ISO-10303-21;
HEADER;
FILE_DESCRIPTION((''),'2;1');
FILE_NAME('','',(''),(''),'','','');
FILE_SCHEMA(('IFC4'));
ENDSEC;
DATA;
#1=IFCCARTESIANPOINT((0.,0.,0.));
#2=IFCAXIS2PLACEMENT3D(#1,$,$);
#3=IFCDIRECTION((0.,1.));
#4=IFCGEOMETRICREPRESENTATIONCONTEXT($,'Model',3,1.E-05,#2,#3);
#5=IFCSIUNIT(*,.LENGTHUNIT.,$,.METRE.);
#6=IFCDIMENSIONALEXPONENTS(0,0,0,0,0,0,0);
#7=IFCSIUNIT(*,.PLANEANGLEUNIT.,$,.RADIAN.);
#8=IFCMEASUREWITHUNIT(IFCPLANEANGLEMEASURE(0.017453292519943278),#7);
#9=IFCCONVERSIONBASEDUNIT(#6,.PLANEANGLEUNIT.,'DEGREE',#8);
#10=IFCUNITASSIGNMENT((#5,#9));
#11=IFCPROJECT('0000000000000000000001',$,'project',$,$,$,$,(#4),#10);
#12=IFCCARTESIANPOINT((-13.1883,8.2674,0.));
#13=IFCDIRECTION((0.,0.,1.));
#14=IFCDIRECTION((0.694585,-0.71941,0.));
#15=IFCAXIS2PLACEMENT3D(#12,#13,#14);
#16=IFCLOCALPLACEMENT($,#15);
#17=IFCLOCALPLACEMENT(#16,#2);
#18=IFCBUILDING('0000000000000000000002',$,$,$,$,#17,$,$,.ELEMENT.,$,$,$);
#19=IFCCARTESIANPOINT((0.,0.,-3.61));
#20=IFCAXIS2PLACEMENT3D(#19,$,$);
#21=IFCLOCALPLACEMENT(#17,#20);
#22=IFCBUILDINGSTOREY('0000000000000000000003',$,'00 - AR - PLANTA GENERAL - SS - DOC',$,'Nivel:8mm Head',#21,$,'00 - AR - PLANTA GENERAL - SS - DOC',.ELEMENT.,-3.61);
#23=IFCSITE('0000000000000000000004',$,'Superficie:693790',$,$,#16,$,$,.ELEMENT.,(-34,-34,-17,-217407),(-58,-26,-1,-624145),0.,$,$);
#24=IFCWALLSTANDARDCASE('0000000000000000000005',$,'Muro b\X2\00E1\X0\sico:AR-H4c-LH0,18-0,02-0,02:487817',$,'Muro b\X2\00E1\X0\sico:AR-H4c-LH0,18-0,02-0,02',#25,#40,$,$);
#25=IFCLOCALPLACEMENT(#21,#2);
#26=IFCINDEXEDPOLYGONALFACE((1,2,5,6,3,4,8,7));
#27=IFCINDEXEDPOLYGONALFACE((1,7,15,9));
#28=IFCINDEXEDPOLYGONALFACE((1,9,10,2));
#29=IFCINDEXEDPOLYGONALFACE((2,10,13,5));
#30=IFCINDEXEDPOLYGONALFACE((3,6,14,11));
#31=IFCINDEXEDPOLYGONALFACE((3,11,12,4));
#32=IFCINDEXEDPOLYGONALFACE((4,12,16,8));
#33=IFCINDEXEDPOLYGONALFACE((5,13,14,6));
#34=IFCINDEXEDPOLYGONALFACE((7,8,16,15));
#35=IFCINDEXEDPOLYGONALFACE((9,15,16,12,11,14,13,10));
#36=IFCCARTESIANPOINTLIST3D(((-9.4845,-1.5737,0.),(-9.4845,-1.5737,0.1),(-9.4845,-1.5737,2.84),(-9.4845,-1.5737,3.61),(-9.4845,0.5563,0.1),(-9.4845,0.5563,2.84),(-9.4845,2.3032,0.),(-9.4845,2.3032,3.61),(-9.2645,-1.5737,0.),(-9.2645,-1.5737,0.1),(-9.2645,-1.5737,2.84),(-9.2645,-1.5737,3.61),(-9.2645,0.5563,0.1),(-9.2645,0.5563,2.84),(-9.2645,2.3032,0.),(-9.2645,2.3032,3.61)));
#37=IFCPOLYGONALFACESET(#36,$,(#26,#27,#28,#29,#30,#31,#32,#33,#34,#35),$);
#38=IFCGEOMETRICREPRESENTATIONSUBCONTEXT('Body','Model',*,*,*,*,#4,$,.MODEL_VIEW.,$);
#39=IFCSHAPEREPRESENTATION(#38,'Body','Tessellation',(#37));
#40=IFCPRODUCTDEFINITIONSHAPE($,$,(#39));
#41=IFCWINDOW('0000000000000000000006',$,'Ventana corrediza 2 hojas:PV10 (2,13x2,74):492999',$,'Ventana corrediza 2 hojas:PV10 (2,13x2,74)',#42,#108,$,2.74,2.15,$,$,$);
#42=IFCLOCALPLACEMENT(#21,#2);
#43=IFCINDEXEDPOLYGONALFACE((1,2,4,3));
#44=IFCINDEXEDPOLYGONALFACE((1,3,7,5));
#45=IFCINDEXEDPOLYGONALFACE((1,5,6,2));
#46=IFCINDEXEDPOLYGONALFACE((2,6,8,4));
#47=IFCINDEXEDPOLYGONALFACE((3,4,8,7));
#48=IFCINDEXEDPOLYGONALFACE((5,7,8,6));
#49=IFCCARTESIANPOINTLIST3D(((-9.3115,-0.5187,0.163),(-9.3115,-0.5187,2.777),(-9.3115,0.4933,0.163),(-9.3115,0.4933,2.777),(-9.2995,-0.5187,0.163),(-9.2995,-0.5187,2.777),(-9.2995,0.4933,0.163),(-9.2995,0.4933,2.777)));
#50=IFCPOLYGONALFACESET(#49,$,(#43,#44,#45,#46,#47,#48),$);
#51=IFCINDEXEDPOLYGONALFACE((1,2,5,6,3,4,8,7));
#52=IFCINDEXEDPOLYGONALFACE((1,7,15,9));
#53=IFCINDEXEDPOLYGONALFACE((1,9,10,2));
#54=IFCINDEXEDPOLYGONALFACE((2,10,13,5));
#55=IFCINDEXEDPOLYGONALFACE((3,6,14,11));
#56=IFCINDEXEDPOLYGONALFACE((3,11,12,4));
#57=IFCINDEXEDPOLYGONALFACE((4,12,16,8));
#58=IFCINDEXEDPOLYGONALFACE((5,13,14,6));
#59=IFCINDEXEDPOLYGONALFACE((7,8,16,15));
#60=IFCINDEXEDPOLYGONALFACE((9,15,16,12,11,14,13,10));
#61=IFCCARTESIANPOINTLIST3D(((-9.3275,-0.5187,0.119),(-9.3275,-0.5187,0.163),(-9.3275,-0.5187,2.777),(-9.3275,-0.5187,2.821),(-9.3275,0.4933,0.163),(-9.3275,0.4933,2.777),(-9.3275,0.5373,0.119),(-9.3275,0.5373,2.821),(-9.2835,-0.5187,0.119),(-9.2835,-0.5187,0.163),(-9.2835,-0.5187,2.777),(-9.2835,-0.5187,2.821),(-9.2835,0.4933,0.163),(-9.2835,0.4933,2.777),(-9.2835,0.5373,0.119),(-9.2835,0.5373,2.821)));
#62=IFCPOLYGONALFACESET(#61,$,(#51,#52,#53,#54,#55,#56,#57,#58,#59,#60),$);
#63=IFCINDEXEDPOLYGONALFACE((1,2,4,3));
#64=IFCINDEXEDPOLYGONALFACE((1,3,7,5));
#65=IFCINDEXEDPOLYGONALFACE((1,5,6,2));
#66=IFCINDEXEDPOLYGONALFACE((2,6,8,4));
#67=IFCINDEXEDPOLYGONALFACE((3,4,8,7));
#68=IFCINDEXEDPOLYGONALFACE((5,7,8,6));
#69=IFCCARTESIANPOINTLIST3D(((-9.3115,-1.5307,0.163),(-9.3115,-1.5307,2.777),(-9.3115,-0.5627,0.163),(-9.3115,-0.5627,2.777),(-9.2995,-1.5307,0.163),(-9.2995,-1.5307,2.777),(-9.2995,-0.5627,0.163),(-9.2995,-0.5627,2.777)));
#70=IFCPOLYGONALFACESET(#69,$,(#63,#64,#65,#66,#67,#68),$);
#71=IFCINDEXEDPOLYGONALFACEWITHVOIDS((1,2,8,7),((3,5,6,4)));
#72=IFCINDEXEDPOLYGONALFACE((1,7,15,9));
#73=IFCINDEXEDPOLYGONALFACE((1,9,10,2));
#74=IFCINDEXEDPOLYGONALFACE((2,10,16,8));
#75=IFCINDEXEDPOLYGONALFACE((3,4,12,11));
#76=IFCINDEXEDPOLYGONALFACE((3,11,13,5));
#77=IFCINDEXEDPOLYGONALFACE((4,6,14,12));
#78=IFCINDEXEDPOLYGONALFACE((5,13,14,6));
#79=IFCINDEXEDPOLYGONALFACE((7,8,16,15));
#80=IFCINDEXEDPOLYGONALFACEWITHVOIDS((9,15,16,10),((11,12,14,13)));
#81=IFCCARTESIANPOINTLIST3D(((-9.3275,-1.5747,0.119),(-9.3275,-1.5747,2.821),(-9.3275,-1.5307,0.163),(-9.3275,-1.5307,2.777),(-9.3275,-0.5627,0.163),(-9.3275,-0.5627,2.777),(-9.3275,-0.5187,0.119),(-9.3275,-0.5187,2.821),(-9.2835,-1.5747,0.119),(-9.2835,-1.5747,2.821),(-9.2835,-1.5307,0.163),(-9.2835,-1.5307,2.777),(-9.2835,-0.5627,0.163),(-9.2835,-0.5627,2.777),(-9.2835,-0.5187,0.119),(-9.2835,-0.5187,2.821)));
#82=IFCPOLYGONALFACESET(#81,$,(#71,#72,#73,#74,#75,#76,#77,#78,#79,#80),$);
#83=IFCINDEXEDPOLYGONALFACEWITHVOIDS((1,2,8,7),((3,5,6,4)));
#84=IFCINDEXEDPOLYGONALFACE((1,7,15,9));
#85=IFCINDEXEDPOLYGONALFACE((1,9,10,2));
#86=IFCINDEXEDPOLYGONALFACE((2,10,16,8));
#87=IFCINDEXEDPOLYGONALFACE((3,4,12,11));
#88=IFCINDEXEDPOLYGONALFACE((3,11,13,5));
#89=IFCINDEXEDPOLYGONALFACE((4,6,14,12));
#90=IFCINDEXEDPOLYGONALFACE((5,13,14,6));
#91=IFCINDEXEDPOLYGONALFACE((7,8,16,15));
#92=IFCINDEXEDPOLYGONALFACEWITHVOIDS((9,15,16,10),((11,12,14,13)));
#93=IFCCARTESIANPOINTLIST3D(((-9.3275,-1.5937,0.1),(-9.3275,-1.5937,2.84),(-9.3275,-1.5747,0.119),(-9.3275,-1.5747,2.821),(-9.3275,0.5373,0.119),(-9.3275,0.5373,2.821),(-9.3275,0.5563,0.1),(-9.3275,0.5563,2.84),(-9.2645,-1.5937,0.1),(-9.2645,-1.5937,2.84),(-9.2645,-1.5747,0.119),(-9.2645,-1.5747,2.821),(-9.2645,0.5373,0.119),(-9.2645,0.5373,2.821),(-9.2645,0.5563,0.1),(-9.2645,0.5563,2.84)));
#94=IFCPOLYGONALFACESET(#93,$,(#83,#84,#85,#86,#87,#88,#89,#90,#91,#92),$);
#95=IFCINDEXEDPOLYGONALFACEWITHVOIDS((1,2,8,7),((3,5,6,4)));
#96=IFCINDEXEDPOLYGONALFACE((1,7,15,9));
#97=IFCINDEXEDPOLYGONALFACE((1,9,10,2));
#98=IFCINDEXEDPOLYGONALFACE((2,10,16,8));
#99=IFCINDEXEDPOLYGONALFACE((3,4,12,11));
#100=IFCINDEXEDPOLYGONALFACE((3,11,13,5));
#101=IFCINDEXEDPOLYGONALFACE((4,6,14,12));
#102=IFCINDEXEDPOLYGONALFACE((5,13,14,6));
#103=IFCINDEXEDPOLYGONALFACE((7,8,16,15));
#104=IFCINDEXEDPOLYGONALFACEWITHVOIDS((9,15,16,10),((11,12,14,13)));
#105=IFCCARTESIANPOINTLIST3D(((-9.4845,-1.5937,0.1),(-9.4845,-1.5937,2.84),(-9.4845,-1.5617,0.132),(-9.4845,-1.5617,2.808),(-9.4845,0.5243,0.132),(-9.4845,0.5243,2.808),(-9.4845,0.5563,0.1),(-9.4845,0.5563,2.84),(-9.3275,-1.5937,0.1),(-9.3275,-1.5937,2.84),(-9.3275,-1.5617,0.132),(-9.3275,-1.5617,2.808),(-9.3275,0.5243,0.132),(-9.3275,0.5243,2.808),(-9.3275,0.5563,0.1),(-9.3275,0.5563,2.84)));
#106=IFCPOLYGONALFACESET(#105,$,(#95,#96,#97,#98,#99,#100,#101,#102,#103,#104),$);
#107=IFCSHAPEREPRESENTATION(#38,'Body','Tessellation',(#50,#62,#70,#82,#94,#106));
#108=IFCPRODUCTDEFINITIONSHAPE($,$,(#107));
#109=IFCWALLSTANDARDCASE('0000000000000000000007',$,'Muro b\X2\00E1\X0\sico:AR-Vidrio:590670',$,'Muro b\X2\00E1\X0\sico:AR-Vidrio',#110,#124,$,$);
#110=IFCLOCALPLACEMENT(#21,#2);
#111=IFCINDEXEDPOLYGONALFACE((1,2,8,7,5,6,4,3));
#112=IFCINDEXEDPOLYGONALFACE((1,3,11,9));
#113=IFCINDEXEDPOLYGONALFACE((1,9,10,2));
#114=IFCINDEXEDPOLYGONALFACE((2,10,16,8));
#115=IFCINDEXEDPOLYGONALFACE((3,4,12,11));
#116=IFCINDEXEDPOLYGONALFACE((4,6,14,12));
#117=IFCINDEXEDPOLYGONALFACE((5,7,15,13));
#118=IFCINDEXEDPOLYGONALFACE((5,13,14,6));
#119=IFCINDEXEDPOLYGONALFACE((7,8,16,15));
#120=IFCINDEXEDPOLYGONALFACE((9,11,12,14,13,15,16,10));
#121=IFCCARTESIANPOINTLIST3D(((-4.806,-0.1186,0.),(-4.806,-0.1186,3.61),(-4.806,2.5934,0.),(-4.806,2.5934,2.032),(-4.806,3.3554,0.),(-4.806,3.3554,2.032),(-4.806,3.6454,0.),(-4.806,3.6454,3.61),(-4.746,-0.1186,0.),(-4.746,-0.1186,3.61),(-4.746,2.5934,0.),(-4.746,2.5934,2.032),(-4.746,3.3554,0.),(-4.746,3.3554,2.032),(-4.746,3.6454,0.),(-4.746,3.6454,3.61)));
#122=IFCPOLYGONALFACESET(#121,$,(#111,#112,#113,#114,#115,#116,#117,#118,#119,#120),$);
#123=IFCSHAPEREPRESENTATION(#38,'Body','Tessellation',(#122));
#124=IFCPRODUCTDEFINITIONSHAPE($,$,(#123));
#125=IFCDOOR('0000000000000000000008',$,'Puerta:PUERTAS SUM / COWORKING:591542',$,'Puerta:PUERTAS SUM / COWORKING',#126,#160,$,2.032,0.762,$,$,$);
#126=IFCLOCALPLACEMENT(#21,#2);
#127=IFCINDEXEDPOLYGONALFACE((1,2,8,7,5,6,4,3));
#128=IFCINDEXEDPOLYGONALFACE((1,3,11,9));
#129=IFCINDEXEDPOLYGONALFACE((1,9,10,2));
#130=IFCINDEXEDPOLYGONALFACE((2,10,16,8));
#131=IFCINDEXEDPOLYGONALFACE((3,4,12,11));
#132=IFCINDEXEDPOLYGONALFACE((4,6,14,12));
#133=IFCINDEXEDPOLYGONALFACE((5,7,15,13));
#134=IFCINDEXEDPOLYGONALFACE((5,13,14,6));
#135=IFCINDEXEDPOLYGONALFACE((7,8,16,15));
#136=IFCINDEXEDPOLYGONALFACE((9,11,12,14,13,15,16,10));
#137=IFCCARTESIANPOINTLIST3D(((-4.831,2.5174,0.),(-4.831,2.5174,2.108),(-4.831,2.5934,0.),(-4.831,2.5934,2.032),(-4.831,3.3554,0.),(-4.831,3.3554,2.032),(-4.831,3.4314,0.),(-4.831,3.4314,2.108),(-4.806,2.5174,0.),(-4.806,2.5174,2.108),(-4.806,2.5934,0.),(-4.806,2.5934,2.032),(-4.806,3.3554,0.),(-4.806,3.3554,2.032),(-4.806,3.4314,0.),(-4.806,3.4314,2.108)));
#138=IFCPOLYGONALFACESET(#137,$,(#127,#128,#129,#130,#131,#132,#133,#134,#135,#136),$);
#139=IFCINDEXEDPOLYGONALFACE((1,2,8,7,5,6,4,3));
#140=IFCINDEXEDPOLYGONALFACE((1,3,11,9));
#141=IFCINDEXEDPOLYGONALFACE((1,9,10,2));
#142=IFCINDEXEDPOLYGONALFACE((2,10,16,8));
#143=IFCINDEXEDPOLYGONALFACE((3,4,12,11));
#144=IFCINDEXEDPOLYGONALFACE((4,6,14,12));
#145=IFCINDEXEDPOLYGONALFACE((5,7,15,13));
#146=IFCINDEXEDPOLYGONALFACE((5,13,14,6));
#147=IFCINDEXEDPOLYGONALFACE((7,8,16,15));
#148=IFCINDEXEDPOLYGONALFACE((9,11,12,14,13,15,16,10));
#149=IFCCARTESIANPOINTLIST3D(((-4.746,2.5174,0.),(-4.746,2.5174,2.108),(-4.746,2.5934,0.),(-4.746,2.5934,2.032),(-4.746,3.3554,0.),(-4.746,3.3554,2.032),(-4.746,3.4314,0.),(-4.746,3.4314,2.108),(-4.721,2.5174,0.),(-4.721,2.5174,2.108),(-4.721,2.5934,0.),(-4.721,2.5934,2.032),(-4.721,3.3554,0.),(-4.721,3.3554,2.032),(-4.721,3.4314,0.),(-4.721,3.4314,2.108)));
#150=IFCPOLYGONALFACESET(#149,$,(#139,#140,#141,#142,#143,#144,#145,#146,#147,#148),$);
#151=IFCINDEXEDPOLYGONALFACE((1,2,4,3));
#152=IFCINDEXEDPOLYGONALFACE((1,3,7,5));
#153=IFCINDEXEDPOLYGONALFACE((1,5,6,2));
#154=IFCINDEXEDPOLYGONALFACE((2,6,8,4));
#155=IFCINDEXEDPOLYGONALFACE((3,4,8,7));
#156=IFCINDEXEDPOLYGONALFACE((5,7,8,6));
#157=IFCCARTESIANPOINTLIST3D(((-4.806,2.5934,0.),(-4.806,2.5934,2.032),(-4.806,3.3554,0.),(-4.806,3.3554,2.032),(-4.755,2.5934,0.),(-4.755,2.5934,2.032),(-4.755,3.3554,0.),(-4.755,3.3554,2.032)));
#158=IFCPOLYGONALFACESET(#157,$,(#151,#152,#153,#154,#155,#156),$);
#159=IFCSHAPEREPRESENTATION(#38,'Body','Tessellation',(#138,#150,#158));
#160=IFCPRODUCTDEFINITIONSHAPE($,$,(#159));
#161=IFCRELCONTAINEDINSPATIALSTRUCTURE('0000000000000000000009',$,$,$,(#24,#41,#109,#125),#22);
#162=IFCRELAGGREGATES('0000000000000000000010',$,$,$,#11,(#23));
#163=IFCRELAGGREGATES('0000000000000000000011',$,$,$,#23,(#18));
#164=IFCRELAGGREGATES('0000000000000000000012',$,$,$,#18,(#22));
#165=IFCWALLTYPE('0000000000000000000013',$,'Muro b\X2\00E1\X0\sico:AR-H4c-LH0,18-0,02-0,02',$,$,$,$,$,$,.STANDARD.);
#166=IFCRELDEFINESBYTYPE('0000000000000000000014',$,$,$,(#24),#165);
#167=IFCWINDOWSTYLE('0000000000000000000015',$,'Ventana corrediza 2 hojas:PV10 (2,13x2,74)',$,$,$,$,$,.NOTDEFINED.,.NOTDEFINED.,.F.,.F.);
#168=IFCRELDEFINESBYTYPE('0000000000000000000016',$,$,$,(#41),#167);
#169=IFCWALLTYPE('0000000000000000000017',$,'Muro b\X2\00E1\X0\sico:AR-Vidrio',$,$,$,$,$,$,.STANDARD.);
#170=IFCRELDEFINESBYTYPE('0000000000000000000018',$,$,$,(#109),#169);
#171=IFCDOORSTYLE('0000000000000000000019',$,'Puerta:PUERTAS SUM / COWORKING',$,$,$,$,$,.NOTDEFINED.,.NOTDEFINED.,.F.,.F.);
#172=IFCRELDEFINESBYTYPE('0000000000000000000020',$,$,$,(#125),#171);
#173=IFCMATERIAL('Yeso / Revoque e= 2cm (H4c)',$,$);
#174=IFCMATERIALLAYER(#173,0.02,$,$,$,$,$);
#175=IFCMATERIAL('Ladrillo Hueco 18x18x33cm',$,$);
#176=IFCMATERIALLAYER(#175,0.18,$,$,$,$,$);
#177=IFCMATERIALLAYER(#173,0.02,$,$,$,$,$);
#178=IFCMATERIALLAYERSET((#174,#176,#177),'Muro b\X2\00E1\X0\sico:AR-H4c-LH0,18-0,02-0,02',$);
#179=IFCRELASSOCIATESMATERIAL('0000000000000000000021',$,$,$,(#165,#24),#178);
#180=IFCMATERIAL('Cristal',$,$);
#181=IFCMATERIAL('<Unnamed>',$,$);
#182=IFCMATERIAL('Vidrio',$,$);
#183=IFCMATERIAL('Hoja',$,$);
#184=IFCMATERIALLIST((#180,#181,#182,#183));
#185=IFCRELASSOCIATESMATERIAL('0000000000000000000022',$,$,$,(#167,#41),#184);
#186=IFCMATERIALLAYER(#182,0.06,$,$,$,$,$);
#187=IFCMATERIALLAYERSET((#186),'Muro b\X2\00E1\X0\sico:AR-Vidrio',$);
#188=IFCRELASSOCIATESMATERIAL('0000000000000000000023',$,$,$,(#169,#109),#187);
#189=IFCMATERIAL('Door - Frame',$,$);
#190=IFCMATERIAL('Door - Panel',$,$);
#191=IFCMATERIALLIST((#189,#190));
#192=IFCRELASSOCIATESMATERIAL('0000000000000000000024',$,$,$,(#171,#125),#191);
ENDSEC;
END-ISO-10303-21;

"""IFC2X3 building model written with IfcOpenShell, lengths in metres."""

from ifc_helpers import new_model, entity, si_unit, converted_unit, direction, frame, frame_2d, origin, origin_2d_with_axis, place, context, subcontext, project, spatial, polyline, rectangle, outline, extrude, source, transform, mapped, material, material_list, layer, layer_set, layer_usage, type_object, type_shapes, element, fill, save


model = new_model("IFC2X3")

# Units and contexts
model_context = context("Model", 3, precision=1e-05, world=origin(), true_north=direction((0.0, 1.0)))
body_context = subcontext(model_context, "Body", "Model", "MODEL_VIEW")
ifc_project = project(units=[si_unit("LENGTHUNIT", "METRE"), converted_unit("PLANEANGLEUNIT", "DEGREE", entity("IfcPlaneAngleMeasure", 0.017453292519943278), si_unit("PLANEANGLEUNIT", "RADIAN"), dimensions=[0, 0, 0, 0, 0, 0, 0])], contexts=[model_context])

# Site, building, storey
site_placement = place(None, frame((-13.1883, 8.2674, 0.0), z_axis=(0.0, 0.0, 1.0), x_axis=(0.694585, -0.71941, 0.0)))
site = spatial("IfcSite", under=ifc_project, at=site_placement, Name="Superficie:693790", CompositionType="ELEMENT", RefLatitude=(-34, -34, -17, -217407), RefLongitude=(-58, -26, -1, -624145), RefElevation=0.0)
building_placement = place(site_placement, origin())
building = spatial("IfcBuilding", under=site, at=building_placement, CompositionType="ELEMENT")
storey_placement = place(building_placement, frame((0.0, 0.0, -3.61)))
storey = spatial("IfcBuildingStorey", under=building, at=storey_placement, Name="00 - AR - PLANTA GENERAL - SS - DOC", ObjectType="Nivel:8mm Head", LongName="00 - AR - PLANTA GENERAL - SS - DOC", CompositionType="ELEMENT", Elevation=-3.61)

# Shared definitions
ifc_material_1 = material(Name="Door - Frame")
ifc_material_2 = material(Name="Door - Panel")
ifc_material_list_1 = material_list([ifc_material_1, ifc_material_2])

# Shared definitions
ifc_material_3 = material(Name="Vidrio")
ifc_material_4 = material(Name="Hoja")
ifc_material_5 = material(Name="Cristal")
ifc_material_6 = material(Name="<Unnamed>")
ifc_material_list_2 = material_list([ifc_material_5, ifc_material_6, ifc_material_3, ifc_material_4])

# Wall, openings, window
ifc_material_7 = material(Name="Yeso / Revoque e= 2cm (H4c)")
ifc_layer_1 = layer(ifc_material_7, 0.02)
ifc_material_8 = material(Name="Ladrillo Hueco 18x18x33cm")
ifc_layer_2 = layer(ifc_material_8, 0.18)
ifc_layer_3 = layer(ifc_material_7, 0.02)
ifc_layer_set_1 = layer_set([ifc_layer_1, ifc_layer_2, ifc_layer_3], Name="Muro básico:AR-H4c-LH0,18-0,02-0,02")
ifc_layer_usage_1 = layer_usage(ifc_layer_set_1, "AXIS2", "NEGATIVE", 0.11)
wall_type_1 = type_object("IfcWallType", Name="Muro básico:AR-H4c-LH0,18-0,02-0,02", PredefinedType="STANDARD", material=ifc_layer_set_1)
wall_1_placement = place(storey_placement, frame((-9.3745, -1.5737, 0.0), z_axis=(0.0, 0.0, 1.0), x_axis=(0.0, 1.0, 0.0)))
wall_1 = element("IfcWallStandardCase", 1, at=wall_1_placement, inside=storey, type_object=wall_type_1, material=ifc_layer_usage_1, Name="Muro básico:AR-H4c-LH0,18-0,02-0,02:487817", ObjectType="Muro básico:AR-H4c-LH0,18-0,02-0,02", context=body_context, shape_type="SweptSolid", body=[
    extrude(rectangle(XDim=3.8769, YDim=0.22, at=frame_2d((1.9385, 0.0), x_axis=(-1.0, 0.0))), origin(), (0.0, 0.0, 1.0), 3.61),
])
opening_1_placement = place(wall_1_placement, origin())
element("IfcOpeningElement", 2, at=opening_1_placement, cuts=wall_1, ObjectType="Opening", context=body_context, shape_type="SweptSolid", body=[
    extrude(rectangle(XDim=2.74, YDim=0.22, at=frame_2d((0.0, 0.0), x_axis=(0.0, 1.0))), frame((-0.11, -1.5848, 1.47), z_axis=(0.0, 1.0, 0.0), x_axis=(-1.0, 0.0, 0.0)), (0.0, 0.0, 1.0), 1.48),
])
opening_2_placement = place(wall_1_placement, frame((2.13, 0.11, 0.1)))
opening_2 = element("IfcOpeningElement", 3, at=opening_2_placement, cuts=wall_1, ObjectType="Opening", context=body_context, shape_type="SweptSolid", body=[
    extrude(rectangle(XDim=2.74, YDim=2.15, at=frame_2d((1.37, 1.075), x_axis=(1.0, 0.0))), frame((0.0, 0.0, 0.0), z_axis=(0.0, -1.0, 0.0), x_axis=(0.0, 0.0, 1.0)), (0.0, 0.0, 1.0), 0.22),
])
window_style_1 = type_object("IfcWindowStyle", Name="Ventana corrediza 2 hojas:PV10 (2,13x2,74)", ConstructionType="NOTDEFINED", OperationType="NOTDEFINED", ParameterTakesPrecedence=False, Sizeable=False, material=ifc_material_list_2)
shared_shape_1 = source(origin(), body_context, "Body", "SweptSolid", [
    extrude(rectangle(XDim=0.012, YDim=1.012, at=frame_2d((0.0, 0.0), x_axis=(1.0, 0.0))), frame((0.569, 0.179, 0.063), z_axis=(0.0, 0.0, 1.0), x_axis=(0.0, -1.0, 0.0)), (0.0, 0.0, 1.0), 2.614),
    extrude(outline(polyline([(-0.539, -1.351), (0.517, -1.351), (0.517, -1.307), (-0.495, -1.307), (-0.495, 1.307), (0.517, 1.307), (0.517, 1.351), (-0.539, 1.351), (-0.539, -1.351)])), frame((0.558, 0.157, 1.37), z_axis=(0.0, 1.0, 0.0), x_axis=(1.0, 0.0, 0.0)), (0.0, 0.0, 1.0), 0.044),
    extrude(rectangle(XDim=0.012, YDim=0.968, at=frame_2d((0.0, 0.0), x_axis=(1.0, 0.0))), frame((1.603, 0.179, 0.063), z_axis=(0.0, 0.0, 1.0), x_axis=(0.0, -1.0, 0.0)), (0.0, 0.0, 1.0), 2.614),
    extrude(outline(polyline([(-0.528, -1.351), (0.528, -1.351), (0.528, 1.351), (-0.528, 1.351), (-0.528, -1.351)]), holes=[polyline([(-0.484, -1.307), (-0.484, 1.307), (0.484, 1.307), (0.484, -1.307), (-0.484, -1.307)])]), frame((1.603, 0.157, 1.37), z_axis=(0.0, 1.0, 0.0), x_axis=(1.0, 0.0, 0.0)), (0.0, 0.0, 1.0), 0.044),
    extrude(outline(polyline([(-1.075, -1.37), (1.075, -1.37), (1.075, 1.37), (-1.075, 1.37), (-1.075, -1.37)]), holes=[polyline([(-1.056, -1.351), (-1.056, 1.351), (1.056, 1.351), (1.056, -1.351), (-1.056, -1.351)])]), frame((1.075, 0.157, 1.37), z_axis=(0.0, 1.0, 0.0), x_axis=(1.0, 0.0, 0.0)), (0.0, 0.0, 1.0), 0.063),
    extrude(outline(polyline([(-1.075, -1.37), (1.075, -1.37), (1.075, 1.37), (-1.075, 1.37), (-1.075, -1.37)]), holes=[polyline([(-1.043, -1.338), (-1.043, 1.338), (1.043, 1.338), (1.043, -1.338), (-1.043, -1.338)])]), frame((1.075, 0.0, 1.37), z_axis=(0.0, 1.0, 0.0), x_axis=(1.0, 0.0, 0.0)), (0.0, 0.0, 1.0), 0.157),
])
type_shapes(window_style_1, [shared_shape_1])
window_1_placement = place(opening_2_placement, frame((0.0, 0.0, 0.0), z_axis=(0.0, 0.0, 1.0), x_axis=(-1.0, 0.0, 0.0)))
window_1 = element("IfcWindow", 4, at=window_1_placement, inside=storey, type_object=window_style_1, material=ifc_material_list_2, Name="Ventana corrediza 2 hojas:PV10 (2,13x2,74):492999", ObjectType="Ventana corrediza 2 hojas:PV10 (2,13x2,74)", OverallHeight=2.74, OverallWidth=2.15, context=body_context, shape_type="MappedRepresentation", body=[
    mapped(shared_shape_1, transform((0.0, 0.0, 0.0), scale=1.0)),
])
fill(opening_2, window_1)

# Wall, opening, door
ifc_layer_4 = layer(ifc_material_3, 0.06)
ifc_layer_set_2 = layer_set([ifc_layer_4], Name="Muro básico:AR-Vidrio")
ifc_layer_usage_2 = layer_usage(ifc_layer_set_2, "AXIS2", "NEGATIVE", 0.03)
wall_type_2 = type_object("IfcWallType", Name="Muro básico:AR-Vidrio", PredefinedType="STANDARD", material=ifc_layer_set_2)
wall_2_placement = place(storey_placement, frame((-4.776, 3.6454, 0.0), z_axis=(0.0, 0.0, 1.0), x_axis=(0.0, -1.0, 0.0)))
wall_2 = element("IfcWallStandardCase", 5, at=wall_2_placement, inside=storey, type_object=wall_type_2, material=ifc_layer_usage_2, Name="Muro básico:AR-Vidrio:590670", ObjectType="Muro básico:AR-Vidrio", context=body_context, shape_type="SweptSolid", body=[
    extrude(rectangle(XDim=3.7641, YDim=0.06, at=frame_2d((1.882, 0.0), x_axis=(-1.0, 0.0))), origin(), (0.0, 0.0, 1.0), 3.61),
])
opening_3_placement = place(wall_2_placement, frame((1.052, 0.03, 0.0)))
opening_3 = element("IfcOpeningElement", 6, at=opening_3_placement, cuts=wall_2, ObjectType="Opening", context=body_context, shape_type="SweptSolid", body=[
    extrude(rectangle(XDim=0.762, YDim=2.032, at=frame_2d((1.016, 0.381), x_axis=(0.0, 1.0))), frame((0.0, 0.0, 0.0), z_axis=(0.0, -1.0, 0.0), x_axis=(0.0, 0.0, 1.0)), (0.0, 0.0, 1.0), 0.06),
])
door_style_1 = type_object("IfcDoorStyle", Name="Puerta:PUERTAS SUM / COWORKING", ConstructionType="NOTDEFINED", OperationType="NOTDEFINED", ParameterTakesPrecedence=False, Sizeable=False, material=ifc_material_list_1)
shared_shape_2 = source(origin(), body_context, "Body", "SweptSolid", [
    extrude(outline(polyline([(-0.457, -1.073), (0.457, -1.073), (0.457, 1.035), (0.381, 1.035), (0.381, -0.997), (-0.381, -0.997), (-0.381, 1.035), (-0.457, 1.035), (-0.457, -1.073)])), frame((0.381, 0.06, 1.035), z_axis=(0.0, 1.0, 0.0), x_axis=(1.0, 0.0, 0.0)), (0.0, 0.0, 1.0), 0.025),
    extrude(outline(polyline([(-1.073, -0.457), (1.035, -0.457), (1.035, -0.381), (-0.997, -0.381), (-0.997, 0.381), (1.035, 0.381), (1.035, 0.457), (-1.073, 0.457), (-1.073, -0.457)])), frame((0.381, -0.025, 1.035), z_axis=(0.0, 1.0, 0.0), x_axis=(0.0, 0.0, -1.0)), (0.0, 0.0, 1.0), 0.025),
    extrude(rectangle(XDim=0.051, YDim=0.762, at=origin_2d_with_axis()), frame((0.381, 0.0345, 0.0), z_axis=(0.0, 0.0, 1.0), x_axis=(0.0, 1.0, 0.0)), (0.0, 0.0, 1.0), 2.032),
])
type_shapes(door_style_1, [shared_shape_2])
door_1_placement = place(opening_3_placement, frame((0.0, 0.0, 0.0), z_axis=(0.0, 0.0, 1.0), x_axis=(-1.0, 0.0, 0.0)))
door_1 = element("IfcDoor", 7, at=door_1_placement, inside=storey, type_object=door_style_1, material=ifc_material_list_1, Name="Puerta:PUERTAS SUM / COWORKING:591542", ObjectType="Puerta:PUERTAS SUM / COWORKING", OverallHeight=2.032, OverallWidth=0.762, context=body_context, shape_type="MappedRepresentation", body=[
    mapped(shared_shape_2, transform((0.0, 0.0, 0.0), scale=1.0)),
])
fill(opening_3, door_1)

save(model, "model.ifc")
